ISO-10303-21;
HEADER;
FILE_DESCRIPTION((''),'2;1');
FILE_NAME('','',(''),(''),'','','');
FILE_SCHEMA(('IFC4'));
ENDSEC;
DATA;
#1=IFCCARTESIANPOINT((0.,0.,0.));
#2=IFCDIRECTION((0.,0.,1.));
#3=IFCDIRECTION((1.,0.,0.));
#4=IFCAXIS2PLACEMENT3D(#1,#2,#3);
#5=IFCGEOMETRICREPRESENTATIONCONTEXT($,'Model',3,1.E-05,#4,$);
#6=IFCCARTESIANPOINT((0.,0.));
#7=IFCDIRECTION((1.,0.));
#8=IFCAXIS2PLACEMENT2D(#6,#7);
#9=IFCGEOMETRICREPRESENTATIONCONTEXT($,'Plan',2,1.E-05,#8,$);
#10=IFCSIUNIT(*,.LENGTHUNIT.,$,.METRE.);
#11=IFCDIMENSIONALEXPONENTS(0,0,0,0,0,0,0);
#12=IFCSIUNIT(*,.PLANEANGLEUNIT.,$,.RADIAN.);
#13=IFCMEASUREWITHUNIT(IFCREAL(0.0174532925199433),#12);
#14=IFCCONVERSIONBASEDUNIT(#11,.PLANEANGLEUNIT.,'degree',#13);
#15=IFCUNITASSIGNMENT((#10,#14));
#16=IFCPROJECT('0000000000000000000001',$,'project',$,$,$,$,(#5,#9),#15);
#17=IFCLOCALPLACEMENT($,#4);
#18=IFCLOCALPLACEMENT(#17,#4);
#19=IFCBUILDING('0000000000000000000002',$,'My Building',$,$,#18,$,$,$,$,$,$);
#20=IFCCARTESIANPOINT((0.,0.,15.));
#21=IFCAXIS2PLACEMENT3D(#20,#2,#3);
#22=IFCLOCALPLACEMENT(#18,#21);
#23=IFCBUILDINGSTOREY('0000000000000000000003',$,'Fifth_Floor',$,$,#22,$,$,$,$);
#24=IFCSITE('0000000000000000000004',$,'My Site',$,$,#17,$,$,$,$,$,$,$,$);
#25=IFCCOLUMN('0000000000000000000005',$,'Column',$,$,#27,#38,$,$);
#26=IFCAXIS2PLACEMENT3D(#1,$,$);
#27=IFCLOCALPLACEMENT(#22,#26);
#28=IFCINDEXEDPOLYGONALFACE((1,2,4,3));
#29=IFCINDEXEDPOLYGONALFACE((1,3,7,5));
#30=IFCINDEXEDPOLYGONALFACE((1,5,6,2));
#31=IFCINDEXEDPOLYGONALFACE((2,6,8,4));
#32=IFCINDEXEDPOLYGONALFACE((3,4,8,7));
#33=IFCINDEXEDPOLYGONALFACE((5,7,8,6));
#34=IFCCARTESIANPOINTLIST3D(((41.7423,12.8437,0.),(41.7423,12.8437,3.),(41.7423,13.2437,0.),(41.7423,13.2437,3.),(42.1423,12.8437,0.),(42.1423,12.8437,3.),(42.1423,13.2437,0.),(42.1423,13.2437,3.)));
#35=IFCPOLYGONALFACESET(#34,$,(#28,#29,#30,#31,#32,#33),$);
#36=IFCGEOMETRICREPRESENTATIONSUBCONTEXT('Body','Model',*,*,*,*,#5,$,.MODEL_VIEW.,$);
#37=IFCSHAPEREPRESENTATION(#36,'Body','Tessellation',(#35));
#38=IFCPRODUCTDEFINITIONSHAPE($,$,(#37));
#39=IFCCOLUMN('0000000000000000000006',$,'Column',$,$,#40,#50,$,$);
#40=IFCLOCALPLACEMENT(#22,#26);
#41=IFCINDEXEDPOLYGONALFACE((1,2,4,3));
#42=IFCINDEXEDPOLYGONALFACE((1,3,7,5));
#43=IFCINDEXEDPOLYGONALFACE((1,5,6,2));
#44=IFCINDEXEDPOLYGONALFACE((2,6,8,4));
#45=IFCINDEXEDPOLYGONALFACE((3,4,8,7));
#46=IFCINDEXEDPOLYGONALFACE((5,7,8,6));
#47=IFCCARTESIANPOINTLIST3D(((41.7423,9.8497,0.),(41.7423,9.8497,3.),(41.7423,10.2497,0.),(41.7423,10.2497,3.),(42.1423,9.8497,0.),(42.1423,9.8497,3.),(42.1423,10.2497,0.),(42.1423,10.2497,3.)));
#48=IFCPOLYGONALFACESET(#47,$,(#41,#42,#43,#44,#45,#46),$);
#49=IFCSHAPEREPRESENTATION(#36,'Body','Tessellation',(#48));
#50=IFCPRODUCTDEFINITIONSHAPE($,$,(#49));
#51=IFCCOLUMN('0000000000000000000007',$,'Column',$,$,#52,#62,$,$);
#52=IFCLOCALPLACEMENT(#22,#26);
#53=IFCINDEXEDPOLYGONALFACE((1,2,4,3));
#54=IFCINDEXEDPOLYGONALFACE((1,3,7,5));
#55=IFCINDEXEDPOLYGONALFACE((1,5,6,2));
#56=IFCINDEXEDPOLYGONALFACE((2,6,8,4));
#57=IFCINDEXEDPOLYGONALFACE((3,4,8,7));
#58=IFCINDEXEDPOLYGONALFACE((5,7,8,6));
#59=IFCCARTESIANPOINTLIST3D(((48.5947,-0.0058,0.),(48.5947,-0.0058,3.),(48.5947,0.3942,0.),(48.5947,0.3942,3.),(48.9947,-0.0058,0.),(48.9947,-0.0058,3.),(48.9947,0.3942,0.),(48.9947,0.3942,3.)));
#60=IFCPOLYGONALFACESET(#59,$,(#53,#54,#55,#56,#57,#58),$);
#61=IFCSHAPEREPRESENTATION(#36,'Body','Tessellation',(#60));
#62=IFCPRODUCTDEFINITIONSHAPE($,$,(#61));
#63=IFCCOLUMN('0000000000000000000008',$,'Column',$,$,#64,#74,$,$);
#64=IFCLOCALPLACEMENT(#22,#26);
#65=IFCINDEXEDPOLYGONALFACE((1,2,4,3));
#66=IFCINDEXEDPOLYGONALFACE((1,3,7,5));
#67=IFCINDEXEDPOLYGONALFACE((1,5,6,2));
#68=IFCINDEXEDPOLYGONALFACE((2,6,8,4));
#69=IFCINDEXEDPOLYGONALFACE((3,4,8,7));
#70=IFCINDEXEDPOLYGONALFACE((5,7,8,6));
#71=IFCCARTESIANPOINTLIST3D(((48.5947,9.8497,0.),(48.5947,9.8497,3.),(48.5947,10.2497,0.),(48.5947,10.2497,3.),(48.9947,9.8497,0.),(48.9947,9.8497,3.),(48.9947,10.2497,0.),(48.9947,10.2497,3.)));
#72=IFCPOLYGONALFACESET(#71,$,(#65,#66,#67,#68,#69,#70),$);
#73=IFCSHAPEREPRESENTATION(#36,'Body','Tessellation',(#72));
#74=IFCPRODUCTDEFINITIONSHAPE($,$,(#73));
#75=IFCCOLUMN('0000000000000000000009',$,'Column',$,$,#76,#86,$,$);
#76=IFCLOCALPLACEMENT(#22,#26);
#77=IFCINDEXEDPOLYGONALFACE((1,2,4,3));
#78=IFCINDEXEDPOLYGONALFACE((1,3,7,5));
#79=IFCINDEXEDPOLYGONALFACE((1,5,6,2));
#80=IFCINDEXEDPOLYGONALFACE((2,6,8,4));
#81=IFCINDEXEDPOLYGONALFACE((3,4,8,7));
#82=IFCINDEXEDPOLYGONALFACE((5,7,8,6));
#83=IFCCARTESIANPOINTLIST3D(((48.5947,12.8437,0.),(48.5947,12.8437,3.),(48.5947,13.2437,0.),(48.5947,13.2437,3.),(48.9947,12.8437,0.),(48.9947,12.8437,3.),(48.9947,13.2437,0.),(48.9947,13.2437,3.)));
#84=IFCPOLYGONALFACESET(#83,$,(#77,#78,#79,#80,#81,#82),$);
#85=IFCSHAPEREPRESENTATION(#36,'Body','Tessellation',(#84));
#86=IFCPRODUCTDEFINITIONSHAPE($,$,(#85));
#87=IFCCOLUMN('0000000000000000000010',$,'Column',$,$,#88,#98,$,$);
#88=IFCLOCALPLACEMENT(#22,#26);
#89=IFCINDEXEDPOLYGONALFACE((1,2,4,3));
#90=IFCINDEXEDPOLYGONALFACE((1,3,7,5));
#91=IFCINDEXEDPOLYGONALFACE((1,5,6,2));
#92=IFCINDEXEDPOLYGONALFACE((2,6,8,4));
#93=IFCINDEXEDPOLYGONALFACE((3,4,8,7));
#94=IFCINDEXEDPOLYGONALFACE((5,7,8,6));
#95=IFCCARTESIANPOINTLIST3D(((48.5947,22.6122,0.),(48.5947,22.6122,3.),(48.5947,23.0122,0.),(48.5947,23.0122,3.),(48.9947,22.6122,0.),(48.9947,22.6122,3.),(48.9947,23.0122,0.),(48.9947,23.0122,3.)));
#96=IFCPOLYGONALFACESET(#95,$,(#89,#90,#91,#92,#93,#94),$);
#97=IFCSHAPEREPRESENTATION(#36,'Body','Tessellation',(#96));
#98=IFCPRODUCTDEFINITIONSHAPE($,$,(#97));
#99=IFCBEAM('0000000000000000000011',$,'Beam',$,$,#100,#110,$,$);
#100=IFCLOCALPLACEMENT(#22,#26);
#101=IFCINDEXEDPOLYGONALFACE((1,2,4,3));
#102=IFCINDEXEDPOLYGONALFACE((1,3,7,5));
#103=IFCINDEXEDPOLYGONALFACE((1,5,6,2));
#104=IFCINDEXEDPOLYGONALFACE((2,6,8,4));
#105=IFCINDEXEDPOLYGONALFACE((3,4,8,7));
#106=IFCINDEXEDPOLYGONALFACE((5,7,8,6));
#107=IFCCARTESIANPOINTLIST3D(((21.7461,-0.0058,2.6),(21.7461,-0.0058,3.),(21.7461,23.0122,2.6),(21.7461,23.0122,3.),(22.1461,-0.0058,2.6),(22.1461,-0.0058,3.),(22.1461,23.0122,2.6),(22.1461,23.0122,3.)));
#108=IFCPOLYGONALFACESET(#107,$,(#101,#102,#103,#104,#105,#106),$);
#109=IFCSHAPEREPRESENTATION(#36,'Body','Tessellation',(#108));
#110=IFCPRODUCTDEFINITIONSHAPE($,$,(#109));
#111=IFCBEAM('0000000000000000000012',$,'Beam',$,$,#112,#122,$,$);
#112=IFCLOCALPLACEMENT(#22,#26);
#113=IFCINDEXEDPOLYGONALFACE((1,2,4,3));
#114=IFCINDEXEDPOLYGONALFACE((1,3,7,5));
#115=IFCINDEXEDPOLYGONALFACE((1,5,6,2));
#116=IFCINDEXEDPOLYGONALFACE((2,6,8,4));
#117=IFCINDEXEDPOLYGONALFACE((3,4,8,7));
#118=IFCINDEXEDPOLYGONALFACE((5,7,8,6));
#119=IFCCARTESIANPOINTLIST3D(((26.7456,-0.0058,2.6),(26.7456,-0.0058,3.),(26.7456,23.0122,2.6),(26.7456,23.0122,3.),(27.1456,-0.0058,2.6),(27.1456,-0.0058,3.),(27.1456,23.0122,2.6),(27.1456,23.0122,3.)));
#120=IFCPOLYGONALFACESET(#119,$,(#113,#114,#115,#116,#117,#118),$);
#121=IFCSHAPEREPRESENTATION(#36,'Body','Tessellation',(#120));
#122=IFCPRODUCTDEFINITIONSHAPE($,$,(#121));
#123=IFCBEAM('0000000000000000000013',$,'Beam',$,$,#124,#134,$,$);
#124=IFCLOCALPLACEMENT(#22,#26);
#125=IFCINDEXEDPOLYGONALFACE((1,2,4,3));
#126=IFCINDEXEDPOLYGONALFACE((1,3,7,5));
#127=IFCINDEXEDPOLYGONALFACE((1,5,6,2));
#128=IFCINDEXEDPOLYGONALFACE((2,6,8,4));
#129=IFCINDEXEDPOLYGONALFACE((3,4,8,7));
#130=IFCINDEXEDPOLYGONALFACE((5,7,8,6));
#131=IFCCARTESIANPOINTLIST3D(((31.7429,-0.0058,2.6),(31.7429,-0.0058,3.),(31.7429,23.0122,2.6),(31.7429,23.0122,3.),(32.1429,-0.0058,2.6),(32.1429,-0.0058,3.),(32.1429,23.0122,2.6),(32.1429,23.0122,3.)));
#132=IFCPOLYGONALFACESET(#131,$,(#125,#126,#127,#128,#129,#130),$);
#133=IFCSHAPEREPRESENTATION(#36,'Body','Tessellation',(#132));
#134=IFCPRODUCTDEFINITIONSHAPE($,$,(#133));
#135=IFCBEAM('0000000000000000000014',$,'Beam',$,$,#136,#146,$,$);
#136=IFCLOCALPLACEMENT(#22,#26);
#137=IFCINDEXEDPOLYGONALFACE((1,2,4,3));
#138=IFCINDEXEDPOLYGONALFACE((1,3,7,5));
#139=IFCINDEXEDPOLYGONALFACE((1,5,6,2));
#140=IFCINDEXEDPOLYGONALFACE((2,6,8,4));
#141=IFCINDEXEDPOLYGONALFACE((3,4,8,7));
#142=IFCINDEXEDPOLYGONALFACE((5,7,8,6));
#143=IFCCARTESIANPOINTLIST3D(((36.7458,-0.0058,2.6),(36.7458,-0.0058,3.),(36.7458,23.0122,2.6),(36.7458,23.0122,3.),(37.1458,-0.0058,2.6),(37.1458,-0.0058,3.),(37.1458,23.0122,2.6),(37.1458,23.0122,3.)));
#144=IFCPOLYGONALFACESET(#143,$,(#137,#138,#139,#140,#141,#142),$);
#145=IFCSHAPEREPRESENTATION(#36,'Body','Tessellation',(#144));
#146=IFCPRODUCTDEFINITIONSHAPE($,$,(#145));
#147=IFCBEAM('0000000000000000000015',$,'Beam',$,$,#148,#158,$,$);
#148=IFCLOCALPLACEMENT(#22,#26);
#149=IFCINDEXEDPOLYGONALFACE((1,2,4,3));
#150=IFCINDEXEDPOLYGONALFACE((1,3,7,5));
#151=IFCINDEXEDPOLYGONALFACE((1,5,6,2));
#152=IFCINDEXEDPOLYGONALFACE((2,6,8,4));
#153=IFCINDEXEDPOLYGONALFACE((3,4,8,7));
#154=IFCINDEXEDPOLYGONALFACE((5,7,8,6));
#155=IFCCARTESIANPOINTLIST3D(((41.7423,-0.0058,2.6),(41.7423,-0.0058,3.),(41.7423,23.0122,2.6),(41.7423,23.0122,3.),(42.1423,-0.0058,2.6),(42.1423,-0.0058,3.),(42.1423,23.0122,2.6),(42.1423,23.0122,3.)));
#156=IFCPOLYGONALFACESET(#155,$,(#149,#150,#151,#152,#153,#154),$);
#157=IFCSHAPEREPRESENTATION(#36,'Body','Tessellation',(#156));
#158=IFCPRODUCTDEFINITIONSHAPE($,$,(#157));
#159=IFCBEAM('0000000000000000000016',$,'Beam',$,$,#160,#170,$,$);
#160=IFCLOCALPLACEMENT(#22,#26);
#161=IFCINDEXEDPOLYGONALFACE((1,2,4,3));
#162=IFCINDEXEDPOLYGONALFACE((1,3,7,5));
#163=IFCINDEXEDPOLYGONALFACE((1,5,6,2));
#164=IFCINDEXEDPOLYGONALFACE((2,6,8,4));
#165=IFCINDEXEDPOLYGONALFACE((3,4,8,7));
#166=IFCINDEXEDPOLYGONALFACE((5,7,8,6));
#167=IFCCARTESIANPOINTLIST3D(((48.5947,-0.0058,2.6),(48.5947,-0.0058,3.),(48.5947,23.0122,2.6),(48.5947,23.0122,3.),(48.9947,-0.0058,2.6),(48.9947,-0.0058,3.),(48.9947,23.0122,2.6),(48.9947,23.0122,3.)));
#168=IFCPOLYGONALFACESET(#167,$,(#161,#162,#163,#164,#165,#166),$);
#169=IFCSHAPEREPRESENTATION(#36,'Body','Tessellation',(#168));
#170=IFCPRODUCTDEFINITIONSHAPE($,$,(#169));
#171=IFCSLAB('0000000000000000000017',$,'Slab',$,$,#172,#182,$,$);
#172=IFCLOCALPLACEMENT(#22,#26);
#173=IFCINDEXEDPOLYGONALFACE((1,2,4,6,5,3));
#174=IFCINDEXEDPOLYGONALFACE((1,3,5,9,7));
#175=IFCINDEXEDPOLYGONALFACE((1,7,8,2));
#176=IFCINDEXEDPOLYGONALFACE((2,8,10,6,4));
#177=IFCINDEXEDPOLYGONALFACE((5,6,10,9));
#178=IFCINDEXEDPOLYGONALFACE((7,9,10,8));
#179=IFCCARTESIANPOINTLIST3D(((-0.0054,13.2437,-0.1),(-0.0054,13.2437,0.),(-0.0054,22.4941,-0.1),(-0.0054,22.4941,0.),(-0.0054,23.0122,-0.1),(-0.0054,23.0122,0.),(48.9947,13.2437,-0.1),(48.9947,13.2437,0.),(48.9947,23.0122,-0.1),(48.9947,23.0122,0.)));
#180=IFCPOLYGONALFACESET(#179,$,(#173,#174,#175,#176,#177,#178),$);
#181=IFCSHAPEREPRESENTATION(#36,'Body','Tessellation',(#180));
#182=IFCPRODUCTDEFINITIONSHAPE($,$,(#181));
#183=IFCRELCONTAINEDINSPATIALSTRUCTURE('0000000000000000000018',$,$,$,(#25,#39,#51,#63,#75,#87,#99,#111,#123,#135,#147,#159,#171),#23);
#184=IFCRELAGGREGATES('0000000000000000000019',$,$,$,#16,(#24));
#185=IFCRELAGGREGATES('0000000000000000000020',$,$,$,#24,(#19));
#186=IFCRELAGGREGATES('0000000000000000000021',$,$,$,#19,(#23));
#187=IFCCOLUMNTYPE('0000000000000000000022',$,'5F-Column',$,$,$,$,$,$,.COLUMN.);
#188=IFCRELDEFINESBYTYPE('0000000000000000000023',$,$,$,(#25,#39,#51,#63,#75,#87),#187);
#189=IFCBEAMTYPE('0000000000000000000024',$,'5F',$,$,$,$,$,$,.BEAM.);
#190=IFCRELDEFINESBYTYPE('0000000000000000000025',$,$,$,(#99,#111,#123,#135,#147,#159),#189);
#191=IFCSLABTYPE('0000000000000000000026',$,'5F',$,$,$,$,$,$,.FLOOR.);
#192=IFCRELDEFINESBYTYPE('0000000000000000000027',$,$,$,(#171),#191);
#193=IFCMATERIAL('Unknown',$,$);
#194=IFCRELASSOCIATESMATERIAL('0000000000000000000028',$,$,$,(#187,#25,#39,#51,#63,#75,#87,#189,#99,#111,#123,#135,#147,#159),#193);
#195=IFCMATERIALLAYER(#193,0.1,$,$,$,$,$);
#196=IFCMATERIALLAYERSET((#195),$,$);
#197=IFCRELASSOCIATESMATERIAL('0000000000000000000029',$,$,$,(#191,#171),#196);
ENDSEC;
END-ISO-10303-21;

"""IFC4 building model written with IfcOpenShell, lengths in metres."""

from ifc_helpers import new_model, entity, si_unit, converted_unit, frame, origin_with_axes, origin_2d_with_axis, place, context, subcontext, project, spatial, indexed_curve, rectangle, outline, extrude, material, layer, layer_set, layer_usage, material_profile, profile_set, profile_usage, type_object, element, save


model = new_model("IFC4")

# Units and contexts
model_context = context("Model", 3, precision=1e-05, world=origin_with_axes())
plan_context = context("Plan", 2, precision=1e-05, world=origin_2d_with_axis())
body_context = subcontext(model_context, "Body", "Model", "MODEL_VIEW")
ifc_project = project(units=[si_unit("LENGTHUNIT", "METRE"), converted_unit("PLANEANGLEUNIT", "degree", entity("IfcReal", 0.0174532925199433), si_unit("PLANEANGLEUNIT", "RADIAN"), dimensions=[0, 0, 0, 0, 0, 0, 0])], contexts=[model_context, plan_context])

# Site, building, storey
site_placement = place(None, origin_with_axes())
site = spatial("IfcSite", under=ifc_project, at=site_placement, Name="My Site")
building_placement = place(site_placement, origin_with_axes())
building = spatial("IfcBuilding", under=site, at=building_placement, Name="My Building")
storey_placement = place(building_placement, frame((0.0, 0.0, 15.0), z_axis=(0.0, 0.0, 1.0), x_axis=(1.0, 0.0, 0.0)))
storey = spatial("IfcBuildingStorey", under=building, at=storey_placement, Name="Fifth_Floor")

# Columns
ifc_material = material(Name="Unknown")
ifc_material_profile_1 = material_profile(ifc_material, rectangle(XDim=0.4, YDim=0.4))
ifc_profile_set_1 = profile_set([ifc_material_profile_1])
column_type = type_object("IfcColumnType", Name="5F-Column", PredefinedType="COLUMN", material=ifc_profile_set_1)
ifc_profile_usage_1 = profile_usage(ifc_profile_set_1, cardinal=8)
column_1_placement = place(storey_placement, frame((41.9423, 13.2437, 0.0), z_axis=(0.0, 0.0, 1.0), x_axis=(1.0, 0.0, 0.0)))
element("IfcColumn", 1, at=column_1_placement, inside=storey, type_object=column_type, material=ifc_profile_usage_1, Name="Column", context=body_context, shape_type="SweptSolid", body=[
    extrude(rectangle(XDim=0.4, YDim=0.4), frame((0.0, -0.2, 0.0), z_axis=(0.0, 0.0, 1.0), x_axis=(1.0, 0.0, 0.0)), (0.0, 0.0, 1.0), 3.0),
])
ifc_profile_usage_2 = profile_usage(ifc_profile_set_1, cardinal=8)
column_2_placement = place(storey_placement, frame((41.9423, 10.2497, 0.0), z_axis=(0.0, 0.0, 1.0), x_axis=(1.0, 0.0, 0.0)))
element("IfcColumn", 2, at=column_2_placement, inside=storey, type_object=column_type, material=ifc_profile_usage_2, Name="Column", context=body_context, shape_type="SweptSolid", body=[
    extrude(rectangle(XDim=0.4, YDim=0.4), frame((0.0, -0.2, 0.0), z_axis=(0.0, 0.0, 1.0), x_axis=(1.0, 0.0, 0.0)), (0.0, 0.0, 1.0), 3.0),
])
ifc_profile_usage_3 = profile_usage(ifc_profile_set_1, cardinal=8)
column_3_placement = place(storey_placement, frame((48.7947, 0.3942, 0.0), z_axis=(0.0, 0.0, 1.0), x_axis=(1.0, 0.0, 0.0)))
element("IfcColumn", 3, at=column_3_placement, inside=storey, type_object=column_type, material=ifc_profile_usage_3, Name="Column", context=body_context, shape_type="SweptSolid", body=[
    extrude(rectangle(XDim=0.4, YDim=0.4), frame((0.0, -0.2, 0.0), z_axis=(0.0, 0.0, 1.0), x_axis=(1.0, 0.0, 0.0)), (0.0, 0.0, 1.0), 3.0),
])
ifc_profile_usage_4 = profile_usage(ifc_profile_set_1, cardinal=8)
column_4_placement = place(storey_placement, frame((48.7947, 10.2497, 0.0), z_axis=(0.0, 0.0, 1.0), x_axis=(1.0, 0.0, 0.0)))
element("IfcColumn", 4, at=column_4_placement, inside=storey, type_object=column_type, material=ifc_profile_usage_4, Name="Column", context=body_context, shape_type="SweptSolid", body=[
    extrude(rectangle(XDim=0.4, YDim=0.4), frame((0.0, -0.2, 0.0), z_axis=(0.0, 0.0, 1.0), x_axis=(1.0, 0.0, 0.0)), (0.0, 0.0, 1.0), 3.0),
])
ifc_profile_usage_5 = profile_usage(ifc_profile_set_1, cardinal=8)
column_5_placement = place(storey_placement, frame((48.7947, 13.2437, 0.0), z_axis=(0.0, 0.0, 1.0), x_axis=(1.0, 0.0, 0.0)))
element("IfcColumn", 5, at=column_5_placement, inside=storey, type_object=column_type, material=ifc_profile_usage_5, Name="Column", context=body_context, shape_type="SweptSolid", body=[
    extrude(rectangle(XDim=0.4, YDim=0.4), frame((0.0, -0.2, 0.0), z_axis=(0.0, 0.0, 1.0), x_axis=(1.0, 0.0, 0.0)), (0.0, 0.0, 1.0), 3.0),
])
ifc_profile_usage_6 = profile_usage(ifc_profile_set_1, cardinal=8)
column_6_placement = place(storey_placement, frame((48.7947, 23.0122, 0.0), z_axis=(0.0, 0.0, 1.0), x_axis=(1.0, 0.0, 0.0)))
element("IfcColumn", 6, at=column_6_placement, inside=storey, type_object=column_type, material=ifc_profile_usage_6, Name="Column", context=body_context, shape_type="SweptSolid", body=[
    extrude(rectangle(XDim=0.4, YDim=0.4), frame((0.0, -0.2, 0.0), z_axis=(0.0, 0.0, 1.0), x_axis=(1.0, 0.0, 0.0)), (0.0, 0.0, 1.0), 3.0),
])

# Beams
ifc_material_profile_2 = material_profile(ifc_material, rectangle(XDim=0.4, YDim=0.4))
ifc_profile_set_2 = profile_set([ifc_material_profile_2])
ifc_profile_usage_7 = profile_usage(ifc_profile_set_2, cardinal=8)
beam_type = type_object("IfcBeamType", Name="5F", PredefinedType="BEAM", material=ifc_profile_set_2)
beam_1_placement = place(storey_placement, frame((21.9461, -0.0058, 3.0), z_axis=(0.0, 1.0, 0.0), x_axis=(-1.0, 0.0, 0.0)))
element("IfcBeam", 7, at=beam_1_placement, inside=storey, type_object=beam_type, material=ifc_profile_usage_7, Name="Beam", context=body_context, shape_type="SweptSolid", body=[
    extrude(rectangle(XDim=0.4, YDim=0.4), frame((0.0, -0.2, 0.0), z_axis=(0.0, 0.0, 1.0), x_axis=(1.0, 0.0, 0.0)), (0.0, 0.0, 1.0), 23.018),
])
ifc_profile_usage_8 = profile_usage(ifc_profile_set_2, cardinal=8)
beam_2_placement = place(storey_placement, frame((26.9456, -0.0058, 3.0), z_axis=(0.0, 1.0, 0.0), x_axis=(-1.0, 0.0, 0.0)))
element("IfcBeam", 8, at=beam_2_placement, inside=storey, type_object=beam_type, material=ifc_profile_usage_8, Name="Beam", context=body_context, shape_type="SweptSolid", body=[
    extrude(rectangle(XDim=0.4, YDim=0.4), frame((0.0, -0.2, 0.0), z_axis=(0.0, 0.0, 1.0), x_axis=(1.0, 0.0, 0.0)), (0.0, 0.0, 1.0), 23.018),
])
ifc_profile_usage_9 = profile_usage(ifc_profile_set_2, cardinal=8)
beam_3_placement = place(storey_placement, frame((31.9429, -0.0058, 3.0), z_axis=(0.0, 1.0, 0.0), x_axis=(-1.0, 0.0, 0.0)))
element("IfcBeam", 9, at=beam_3_placement, inside=storey, type_object=beam_type, material=ifc_profile_usage_9, Name="Beam", context=body_context, shape_type="SweptSolid", body=[
    extrude(rectangle(XDim=0.4, YDim=0.4), frame((0.0, -0.2, 0.0), z_axis=(0.0, 0.0, 1.0), x_axis=(1.0, 0.0, 0.0)), (0.0, 0.0, 1.0), 23.018),
])
ifc_profile_usage_10 = profile_usage(ifc_profile_set_2, cardinal=8)
beam_4_placement = place(storey_placement, frame((36.9458, -0.0058, 3.0), z_axis=(0.0, 1.0, 0.0), x_axis=(-1.0, 0.0, 0.0)))
element("IfcBeam", 10, at=beam_4_placement, inside=storey, type_object=beam_type, material=ifc_profile_usage_10, Name="Beam", context=body_context, shape_type="SweptSolid", body=[
    extrude(rectangle(XDim=0.4, YDim=0.4), frame((0.0, -0.2, 0.0), z_axis=(0.0, 0.0, 1.0), x_axis=(1.0, 0.0, 0.0)), (0.0, 0.0, 1.0), 23.018),
])
ifc_profile_usage_11 = profile_usage(ifc_profile_set_2, cardinal=8)
beam_5_placement = place(storey_placement, frame((41.9423, -0.0058, 3.0), z_axis=(0.0, 1.0, 0.0), x_axis=(-1.0, 0.0, 0.0)))
element("IfcBeam", 11, at=beam_5_placement, inside=storey, type_object=beam_type, material=ifc_profile_usage_11, Name="Beam", context=body_context, shape_type="SweptSolid", body=[
    extrude(rectangle(XDim=0.4, YDim=0.4), frame((0.0, -0.2, 0.0), z_axis=(0.0, 0.0, 1.0), x_axis=(1.0, 0.0, 0.0)), (0.0, 0.0, 1.0), 23.018),
])
ifc_profile_usage_12 = profile_usage(ifc_profile_set_2, cardinal=8)
beam_6_placement = place(storey_placement, frame((48.7947, -0.0058, 3.0), z_axis=(0.0, 1.0, 0.0), x_axis=(-1.0, 0.0, 0.0)))
element("IfcBeam", 12, at=beam_6_placement, inside=storey, type_object=beam_type, material=ifc_profile_usage_12, Name="Beam", context=body_context, shape_type="SweptSolid", body=[
    extrude(rectangle(XDim=0.4, YDim=0.4), frame((0.0, -0.2, 0.0), z_axis=(0.0, 0.0, 1.0), x_axis=(1.0, 0.0, 0.0)), (0.0, 0.0, 1.0), 23.018),
])

# Slab
ifc_layer = layer(ifc_material, 0.1)
ifc_layer_set = layer_set([ifc_layer])
ifc_layer_usage_1 = layer_usage(ifc_layer_set, "AXIS3", "POSITIVE", -0.1)
slab_type = type_object("IfcSlabType", Name="5F", PredefinedType="FLOOR", material=ifc_layer_set)
slab_1_placement = place(storey_placement, frame((48.9947, 23.0122, 0.0), z_axis=(0.0, 0.0, 1.0), x_axis=(1.0, 0.0, 0.0)))
element("IfcSlab", 13, at=slab_1_placement, inside=storey, type_object=slab_type, material=ifc_layer_usage_1, Name="Slab", context=body_context, shape_type="SweptSolid", body=[
    extrude(outline(indexed_curve([(0.0, 0.0), (-49.0001, 0.0), (-49.0001, -0.5181), (-49.0001, -9.7685), (0.0, -9.7685), (0.0, 0.0)])), frame((0.0, 0.0, -0.1), z_axis=(0.0, 0.0, 1.0), x_axis=(1.0, 0.0, 0.0)), (0.0, 0.0, 1.0), 0.1),
])

save(model, "model.ifc")
